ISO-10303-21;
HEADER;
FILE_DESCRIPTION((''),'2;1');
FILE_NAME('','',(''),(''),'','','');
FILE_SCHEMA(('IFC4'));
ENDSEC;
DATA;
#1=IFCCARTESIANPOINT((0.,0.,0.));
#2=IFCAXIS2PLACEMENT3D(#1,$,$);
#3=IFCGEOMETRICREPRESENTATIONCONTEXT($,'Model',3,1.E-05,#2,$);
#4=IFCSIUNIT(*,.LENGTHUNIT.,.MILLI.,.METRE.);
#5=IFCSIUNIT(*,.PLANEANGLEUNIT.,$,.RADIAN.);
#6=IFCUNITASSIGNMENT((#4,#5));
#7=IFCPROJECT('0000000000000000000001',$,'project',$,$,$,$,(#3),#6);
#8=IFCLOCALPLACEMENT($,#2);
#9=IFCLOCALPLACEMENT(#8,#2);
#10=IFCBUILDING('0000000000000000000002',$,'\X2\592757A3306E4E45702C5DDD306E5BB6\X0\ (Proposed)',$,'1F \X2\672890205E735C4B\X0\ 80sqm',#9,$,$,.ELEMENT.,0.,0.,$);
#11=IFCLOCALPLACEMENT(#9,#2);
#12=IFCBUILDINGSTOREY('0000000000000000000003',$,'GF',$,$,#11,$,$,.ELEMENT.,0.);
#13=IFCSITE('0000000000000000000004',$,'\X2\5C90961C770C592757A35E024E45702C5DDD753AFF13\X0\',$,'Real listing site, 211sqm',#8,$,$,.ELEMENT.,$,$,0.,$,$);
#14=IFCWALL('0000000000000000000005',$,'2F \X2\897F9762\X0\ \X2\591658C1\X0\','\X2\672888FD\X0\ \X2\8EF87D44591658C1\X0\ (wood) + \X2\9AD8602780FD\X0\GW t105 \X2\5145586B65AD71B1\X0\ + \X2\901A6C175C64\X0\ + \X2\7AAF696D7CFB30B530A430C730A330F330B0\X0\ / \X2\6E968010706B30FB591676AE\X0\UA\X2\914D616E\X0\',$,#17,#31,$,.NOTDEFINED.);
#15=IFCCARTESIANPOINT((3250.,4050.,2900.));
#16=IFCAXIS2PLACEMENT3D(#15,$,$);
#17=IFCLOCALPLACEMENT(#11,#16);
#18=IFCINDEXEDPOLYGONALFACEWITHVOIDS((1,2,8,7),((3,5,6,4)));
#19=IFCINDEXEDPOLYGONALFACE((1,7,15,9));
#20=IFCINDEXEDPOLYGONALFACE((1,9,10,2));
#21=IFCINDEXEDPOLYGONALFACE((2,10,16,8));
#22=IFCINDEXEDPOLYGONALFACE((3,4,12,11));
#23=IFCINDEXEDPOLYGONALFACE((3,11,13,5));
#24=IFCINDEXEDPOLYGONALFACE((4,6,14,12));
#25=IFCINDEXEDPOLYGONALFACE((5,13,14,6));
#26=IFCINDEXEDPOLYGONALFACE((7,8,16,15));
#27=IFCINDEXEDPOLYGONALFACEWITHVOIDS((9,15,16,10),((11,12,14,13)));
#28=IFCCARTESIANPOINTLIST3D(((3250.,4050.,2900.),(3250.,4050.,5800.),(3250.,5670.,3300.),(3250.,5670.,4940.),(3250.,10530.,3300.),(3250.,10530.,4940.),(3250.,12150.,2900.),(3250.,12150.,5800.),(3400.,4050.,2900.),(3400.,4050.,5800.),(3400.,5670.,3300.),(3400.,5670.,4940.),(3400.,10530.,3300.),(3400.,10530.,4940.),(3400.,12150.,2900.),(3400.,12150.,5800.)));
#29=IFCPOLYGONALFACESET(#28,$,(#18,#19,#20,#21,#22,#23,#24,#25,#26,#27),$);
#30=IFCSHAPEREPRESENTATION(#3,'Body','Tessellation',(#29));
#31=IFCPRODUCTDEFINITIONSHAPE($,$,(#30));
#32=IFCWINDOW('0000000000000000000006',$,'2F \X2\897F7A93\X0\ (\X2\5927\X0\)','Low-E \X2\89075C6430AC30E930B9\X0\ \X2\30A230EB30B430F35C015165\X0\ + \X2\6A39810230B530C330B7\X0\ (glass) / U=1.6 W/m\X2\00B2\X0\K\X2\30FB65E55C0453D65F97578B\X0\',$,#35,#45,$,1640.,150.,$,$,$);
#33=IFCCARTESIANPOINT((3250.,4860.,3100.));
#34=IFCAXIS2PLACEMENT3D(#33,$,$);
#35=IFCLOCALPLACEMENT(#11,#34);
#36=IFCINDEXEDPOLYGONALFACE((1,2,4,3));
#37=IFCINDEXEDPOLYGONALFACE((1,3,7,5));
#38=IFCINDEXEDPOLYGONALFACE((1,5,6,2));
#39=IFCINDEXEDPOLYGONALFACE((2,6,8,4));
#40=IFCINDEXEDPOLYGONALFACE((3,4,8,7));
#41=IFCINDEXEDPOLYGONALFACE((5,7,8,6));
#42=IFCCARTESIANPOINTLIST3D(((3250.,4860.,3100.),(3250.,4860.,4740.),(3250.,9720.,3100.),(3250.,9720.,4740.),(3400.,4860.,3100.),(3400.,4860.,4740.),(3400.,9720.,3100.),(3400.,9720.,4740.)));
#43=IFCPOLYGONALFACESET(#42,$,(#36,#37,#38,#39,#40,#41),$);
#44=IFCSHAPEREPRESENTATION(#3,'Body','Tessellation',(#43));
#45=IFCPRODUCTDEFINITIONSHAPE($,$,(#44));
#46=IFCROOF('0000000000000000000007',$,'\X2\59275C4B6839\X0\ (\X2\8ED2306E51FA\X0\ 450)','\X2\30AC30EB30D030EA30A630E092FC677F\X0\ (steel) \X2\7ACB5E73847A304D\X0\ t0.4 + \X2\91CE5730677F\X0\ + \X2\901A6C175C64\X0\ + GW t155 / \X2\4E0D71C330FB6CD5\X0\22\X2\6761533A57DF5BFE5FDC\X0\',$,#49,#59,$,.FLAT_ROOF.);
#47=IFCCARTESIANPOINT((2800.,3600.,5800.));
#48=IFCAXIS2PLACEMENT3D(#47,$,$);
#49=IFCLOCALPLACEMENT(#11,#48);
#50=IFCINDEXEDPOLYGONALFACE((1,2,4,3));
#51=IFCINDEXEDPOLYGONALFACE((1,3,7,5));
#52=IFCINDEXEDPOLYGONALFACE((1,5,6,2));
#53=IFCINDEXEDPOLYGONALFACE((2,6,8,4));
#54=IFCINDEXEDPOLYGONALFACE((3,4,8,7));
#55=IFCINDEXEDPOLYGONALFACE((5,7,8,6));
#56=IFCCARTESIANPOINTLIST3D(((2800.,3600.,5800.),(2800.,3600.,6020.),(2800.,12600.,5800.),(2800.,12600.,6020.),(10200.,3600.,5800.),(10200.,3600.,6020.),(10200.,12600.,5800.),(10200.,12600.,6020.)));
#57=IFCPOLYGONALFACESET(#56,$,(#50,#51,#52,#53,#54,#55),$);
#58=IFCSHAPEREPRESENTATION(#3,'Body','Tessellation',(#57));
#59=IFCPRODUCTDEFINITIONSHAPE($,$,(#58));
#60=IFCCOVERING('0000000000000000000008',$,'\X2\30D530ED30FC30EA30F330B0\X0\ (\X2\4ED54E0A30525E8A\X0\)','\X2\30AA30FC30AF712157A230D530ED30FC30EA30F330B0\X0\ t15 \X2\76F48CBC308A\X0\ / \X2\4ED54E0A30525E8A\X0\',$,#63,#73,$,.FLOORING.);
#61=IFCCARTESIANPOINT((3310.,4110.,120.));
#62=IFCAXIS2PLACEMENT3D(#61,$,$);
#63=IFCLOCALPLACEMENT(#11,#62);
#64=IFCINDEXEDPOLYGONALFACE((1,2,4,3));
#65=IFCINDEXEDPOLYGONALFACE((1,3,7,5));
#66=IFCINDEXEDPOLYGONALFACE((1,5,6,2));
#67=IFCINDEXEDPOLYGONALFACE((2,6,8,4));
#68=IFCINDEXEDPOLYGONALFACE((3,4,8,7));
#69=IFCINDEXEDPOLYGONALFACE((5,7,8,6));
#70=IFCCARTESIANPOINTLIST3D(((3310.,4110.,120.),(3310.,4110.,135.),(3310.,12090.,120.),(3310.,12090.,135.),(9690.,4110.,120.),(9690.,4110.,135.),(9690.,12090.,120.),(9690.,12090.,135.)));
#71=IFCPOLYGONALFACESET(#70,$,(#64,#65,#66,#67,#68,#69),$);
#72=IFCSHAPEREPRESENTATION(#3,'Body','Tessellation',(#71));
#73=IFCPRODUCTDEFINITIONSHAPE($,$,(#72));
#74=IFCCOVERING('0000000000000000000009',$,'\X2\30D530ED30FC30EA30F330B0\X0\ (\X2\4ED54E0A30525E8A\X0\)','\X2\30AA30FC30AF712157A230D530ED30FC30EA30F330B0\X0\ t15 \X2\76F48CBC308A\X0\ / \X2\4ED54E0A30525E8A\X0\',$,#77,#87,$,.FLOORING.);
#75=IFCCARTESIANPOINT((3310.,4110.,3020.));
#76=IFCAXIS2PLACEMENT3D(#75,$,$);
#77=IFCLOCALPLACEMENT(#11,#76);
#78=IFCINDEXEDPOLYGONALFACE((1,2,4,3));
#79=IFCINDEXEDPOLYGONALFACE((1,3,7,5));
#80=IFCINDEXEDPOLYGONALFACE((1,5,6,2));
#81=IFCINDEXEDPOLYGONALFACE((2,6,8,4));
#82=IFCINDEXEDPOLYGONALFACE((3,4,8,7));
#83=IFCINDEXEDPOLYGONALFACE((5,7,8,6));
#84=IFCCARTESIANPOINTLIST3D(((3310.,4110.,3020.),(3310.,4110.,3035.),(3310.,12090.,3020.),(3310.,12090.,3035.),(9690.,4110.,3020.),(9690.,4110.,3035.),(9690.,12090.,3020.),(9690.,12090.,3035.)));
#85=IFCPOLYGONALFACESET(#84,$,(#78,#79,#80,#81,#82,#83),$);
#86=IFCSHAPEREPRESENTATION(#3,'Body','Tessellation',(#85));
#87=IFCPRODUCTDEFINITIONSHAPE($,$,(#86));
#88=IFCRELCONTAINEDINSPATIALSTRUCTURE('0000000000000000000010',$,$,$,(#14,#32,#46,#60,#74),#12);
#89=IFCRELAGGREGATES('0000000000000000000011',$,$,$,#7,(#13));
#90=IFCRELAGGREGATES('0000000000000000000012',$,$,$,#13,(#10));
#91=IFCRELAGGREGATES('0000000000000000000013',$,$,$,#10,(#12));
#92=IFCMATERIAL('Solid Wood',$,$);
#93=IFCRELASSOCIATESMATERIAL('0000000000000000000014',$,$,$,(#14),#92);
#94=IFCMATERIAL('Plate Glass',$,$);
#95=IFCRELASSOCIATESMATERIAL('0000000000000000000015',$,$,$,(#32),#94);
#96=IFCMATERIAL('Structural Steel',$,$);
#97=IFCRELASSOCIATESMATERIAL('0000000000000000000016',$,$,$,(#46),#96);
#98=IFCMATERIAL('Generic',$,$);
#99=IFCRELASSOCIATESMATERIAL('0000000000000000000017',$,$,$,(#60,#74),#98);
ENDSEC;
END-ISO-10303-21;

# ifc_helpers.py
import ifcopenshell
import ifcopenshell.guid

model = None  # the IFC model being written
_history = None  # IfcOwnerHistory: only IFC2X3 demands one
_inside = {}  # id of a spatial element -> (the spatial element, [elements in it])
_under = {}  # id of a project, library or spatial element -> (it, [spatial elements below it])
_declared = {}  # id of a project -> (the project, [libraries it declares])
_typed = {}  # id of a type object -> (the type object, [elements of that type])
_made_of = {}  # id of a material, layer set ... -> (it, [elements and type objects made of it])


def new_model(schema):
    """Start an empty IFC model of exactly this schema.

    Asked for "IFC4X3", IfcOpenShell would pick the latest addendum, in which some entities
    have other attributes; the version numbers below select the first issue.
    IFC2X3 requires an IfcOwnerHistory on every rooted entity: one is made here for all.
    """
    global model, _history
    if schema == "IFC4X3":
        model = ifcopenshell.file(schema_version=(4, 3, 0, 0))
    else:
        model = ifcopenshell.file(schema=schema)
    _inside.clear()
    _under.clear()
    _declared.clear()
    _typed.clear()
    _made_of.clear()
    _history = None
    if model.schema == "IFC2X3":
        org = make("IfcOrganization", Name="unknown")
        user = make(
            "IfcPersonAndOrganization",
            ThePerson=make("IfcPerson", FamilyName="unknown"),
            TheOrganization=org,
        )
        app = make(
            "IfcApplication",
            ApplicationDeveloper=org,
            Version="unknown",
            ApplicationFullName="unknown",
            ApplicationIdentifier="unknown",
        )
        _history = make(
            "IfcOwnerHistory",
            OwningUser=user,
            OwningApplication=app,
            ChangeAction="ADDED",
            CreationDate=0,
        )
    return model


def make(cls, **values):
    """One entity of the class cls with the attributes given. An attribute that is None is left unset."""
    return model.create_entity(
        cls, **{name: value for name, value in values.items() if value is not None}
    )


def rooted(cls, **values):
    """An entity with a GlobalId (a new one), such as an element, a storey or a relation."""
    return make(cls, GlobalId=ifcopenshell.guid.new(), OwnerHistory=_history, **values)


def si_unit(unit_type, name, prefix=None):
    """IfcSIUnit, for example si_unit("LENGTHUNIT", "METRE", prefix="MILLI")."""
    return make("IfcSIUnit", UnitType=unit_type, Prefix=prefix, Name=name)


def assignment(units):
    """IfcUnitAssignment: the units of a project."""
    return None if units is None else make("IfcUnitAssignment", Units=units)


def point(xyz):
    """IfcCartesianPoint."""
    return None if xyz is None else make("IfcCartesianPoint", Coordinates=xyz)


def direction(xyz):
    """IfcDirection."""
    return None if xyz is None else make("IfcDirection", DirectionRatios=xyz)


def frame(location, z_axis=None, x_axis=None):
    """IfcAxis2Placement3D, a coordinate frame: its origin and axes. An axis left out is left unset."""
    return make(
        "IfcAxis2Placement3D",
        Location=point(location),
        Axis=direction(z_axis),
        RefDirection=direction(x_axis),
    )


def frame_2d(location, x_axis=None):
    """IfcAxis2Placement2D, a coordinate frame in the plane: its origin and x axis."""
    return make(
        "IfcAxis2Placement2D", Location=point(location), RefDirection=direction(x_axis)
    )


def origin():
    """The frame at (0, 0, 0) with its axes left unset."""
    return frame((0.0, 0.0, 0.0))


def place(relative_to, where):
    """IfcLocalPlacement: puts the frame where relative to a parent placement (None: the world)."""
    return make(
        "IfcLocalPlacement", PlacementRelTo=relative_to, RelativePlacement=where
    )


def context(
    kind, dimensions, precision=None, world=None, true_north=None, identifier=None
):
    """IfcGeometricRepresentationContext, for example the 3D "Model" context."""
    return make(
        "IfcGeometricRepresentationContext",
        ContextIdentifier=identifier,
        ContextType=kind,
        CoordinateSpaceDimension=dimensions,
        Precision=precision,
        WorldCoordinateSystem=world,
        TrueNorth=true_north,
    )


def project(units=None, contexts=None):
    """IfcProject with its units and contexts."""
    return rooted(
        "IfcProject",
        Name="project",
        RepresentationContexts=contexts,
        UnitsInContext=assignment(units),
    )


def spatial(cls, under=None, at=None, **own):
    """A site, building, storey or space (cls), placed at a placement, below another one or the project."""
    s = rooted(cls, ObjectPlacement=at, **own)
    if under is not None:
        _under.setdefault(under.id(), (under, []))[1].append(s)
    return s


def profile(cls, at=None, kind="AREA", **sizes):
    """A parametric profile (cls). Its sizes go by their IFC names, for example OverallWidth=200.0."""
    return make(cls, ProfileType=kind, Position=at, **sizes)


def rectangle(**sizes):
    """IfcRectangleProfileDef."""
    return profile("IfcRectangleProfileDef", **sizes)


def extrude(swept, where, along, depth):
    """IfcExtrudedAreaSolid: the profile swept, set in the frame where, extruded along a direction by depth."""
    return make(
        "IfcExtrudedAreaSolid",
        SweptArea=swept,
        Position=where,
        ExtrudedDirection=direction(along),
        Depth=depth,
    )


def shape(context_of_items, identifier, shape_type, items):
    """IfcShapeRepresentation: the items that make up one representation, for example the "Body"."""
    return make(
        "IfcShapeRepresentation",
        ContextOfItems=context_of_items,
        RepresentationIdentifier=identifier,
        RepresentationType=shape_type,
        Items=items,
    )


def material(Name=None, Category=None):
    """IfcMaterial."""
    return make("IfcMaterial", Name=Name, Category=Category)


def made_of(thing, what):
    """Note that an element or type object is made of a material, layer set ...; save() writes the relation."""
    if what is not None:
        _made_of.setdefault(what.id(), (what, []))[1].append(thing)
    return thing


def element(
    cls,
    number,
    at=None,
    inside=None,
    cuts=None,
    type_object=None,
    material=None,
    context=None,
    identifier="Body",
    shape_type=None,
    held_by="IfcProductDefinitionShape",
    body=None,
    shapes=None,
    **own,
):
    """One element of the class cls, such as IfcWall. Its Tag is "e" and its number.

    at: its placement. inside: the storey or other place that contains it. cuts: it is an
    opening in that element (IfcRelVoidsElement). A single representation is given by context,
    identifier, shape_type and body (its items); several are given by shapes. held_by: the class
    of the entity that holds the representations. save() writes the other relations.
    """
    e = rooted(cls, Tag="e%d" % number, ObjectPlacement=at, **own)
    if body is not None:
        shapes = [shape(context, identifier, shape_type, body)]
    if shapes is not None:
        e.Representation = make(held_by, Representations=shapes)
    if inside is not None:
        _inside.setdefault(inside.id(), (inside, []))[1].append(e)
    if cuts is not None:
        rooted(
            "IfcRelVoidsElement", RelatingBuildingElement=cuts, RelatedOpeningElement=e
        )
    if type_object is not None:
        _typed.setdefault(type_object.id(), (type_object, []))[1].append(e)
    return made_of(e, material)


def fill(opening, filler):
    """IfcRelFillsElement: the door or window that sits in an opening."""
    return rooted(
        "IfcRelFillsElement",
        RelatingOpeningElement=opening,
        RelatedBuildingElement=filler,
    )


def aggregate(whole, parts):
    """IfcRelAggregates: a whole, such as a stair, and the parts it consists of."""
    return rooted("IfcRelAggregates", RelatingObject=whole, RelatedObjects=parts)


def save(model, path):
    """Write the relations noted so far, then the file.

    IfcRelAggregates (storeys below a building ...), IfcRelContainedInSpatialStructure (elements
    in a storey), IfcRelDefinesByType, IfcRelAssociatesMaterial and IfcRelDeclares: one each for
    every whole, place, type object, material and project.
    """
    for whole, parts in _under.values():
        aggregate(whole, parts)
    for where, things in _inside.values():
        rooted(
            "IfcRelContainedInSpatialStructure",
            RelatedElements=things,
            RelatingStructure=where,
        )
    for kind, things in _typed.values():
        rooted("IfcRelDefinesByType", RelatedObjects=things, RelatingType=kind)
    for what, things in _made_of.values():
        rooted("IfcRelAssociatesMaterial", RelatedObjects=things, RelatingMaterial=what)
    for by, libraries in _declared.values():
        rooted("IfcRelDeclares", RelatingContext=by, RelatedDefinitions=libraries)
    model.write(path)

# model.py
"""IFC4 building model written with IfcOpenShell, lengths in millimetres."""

from ifc_helpers import new_model, si_unit, frame, frame_2d, origin, place, context, project, spatial, rectangle, extrude, material, element, fill, save


model = new_model("IFC4")

# Units and contexts
model_context = context("Model", 3, precision=1e-05, world=origin())
ifc_project = project(units=[si_unit("LENGTHUNIT", "METRE", prefix="MILLI"), si_unit("PLANEANGLEUNIT", "RADIAN")], contexts=[model_context])

# Site, building, storey
site_placement = place(None, origin())
site = spatial("IfcSite", under=ifc_project, at=site_placement, Name="岐阜県大垣市久瀬川町３", ObjectType="Real listing site, 211sqm", CompositionType="ELEMENT", RefElevation=0.0)
building_placement = place(site_placement, origin())
building = spatial("IfcBuilding", under=site, at=building_placement, Name="大垣の久瀬川の家 (Proposed)", ObjectType="1F 木造平屋 80sqm", CompositionType="ELEMENT", ElevationOfRefHeight=0.0, ElevationOfTerrain=0.0)
storey_placement = place(building_placement, origin())
storey = spatial("IfcBuildingStorey", under=building, at=storey_placement, Name="GF", CompositionType="ELEMENT", Elevation=0.0)

# Shared definitions
ifc_material_1 = material(Name="Solid Wood")
ifc_material_2 = material(Name="Generic")

# Shared definitions
ifc_material_3 = material(Name="Plate Glass")

# Wall, opening, window
wall_1_placement = place(storey_placement, frame((3250.0, 4050.0, 2900.0)))
wall_1 = element("IfcWall", 1, at=wall_1_placement, inside=storey, material=ifc_material_1, Name="2F 西面 外壁", Description="木製 軸組外壁 (wood) + 高性能GW t105 充填断熱 + 通気層 + 窯業系サイディング / 準耐火・外皮UA配慮", PredefinedType="NOTDEFINED", context=model_context, shape_type="SweptSolid", body=[
    extrude(rectangle(XDim=150.0, YDim=8100.0, at=frame_2d((75.0, 4050.0))), frame((3250.0, 4050.0, 2900.0)), (0.0, 0.0, 1.0), 2900.0),
])
opening_1_placement = place(storey_placement, frame((3250.0, 4860.0, 3100.0)))
opening_1 = element("IfcOpeningElement", 2, at=opening_1_placement, cuts=wall_1, PredefinedType="NOTDEFINED", context=model_context, shape_type="SweptSolid", body=[
    extrude(rectangle(XDim=150.0, YDim=4860.0, at=frame_2d((75.0, 2430.0))), frame((3250.0, 4860.0, 3100.0)), (0.0, 0.0, 1.0), 1640.0),
])
window_1_placement = place(storey_placement, frame((3250.0, 4860.0, 3100.0)))
window_1 = element("IfcWindow", 3, at=window_1_placement, inside=storey, material=ifc_material_3, Name="2F 西窓 (大)", Description="Low-E 複層ガラス アルゴン封入 + 樹脂サッシ (glass) / U=1.6 W/m²K・日射取得型", OverallHeight=1640.0, OverallWidth=150.0, context=model_context, shape_type="SweptSolid", body=[
    extrude(rectangle(XDim=150.0, YDim=4860.0, at=frame_2d((75.0, 2430.0))), frame((3250.0, 4860.0, 3100.0)), (0.0, 0.0, 1.0), 1640.0),
])
fill(opening_1, window_1)

# Roof
ifc_material_4 = material(Name="Structural Steel")
roof_placement = place(storey_placement, frame((2800.0, 3600.0, 5800.0)))
element("IfcRoof", 4, at=roof_placement, inside=storey, material=ifc_material_4, Name="大屋根 (軒の出 450)", Description="ガルバリウム鋼板 (steel) 立平葺き t0.4 + 野地板 + 通気層 + GW t155 / 不燃・法22条区域対応", PredefinedType="FLAT_ROOF", context=model_context, shape_type="SweptSolid", body=[
    extrude(rectangle(XDim=7400.0, YDim=9000.0, at=frame_2d((3700.0, 4500.0))), frame((2800.0, 3600.0, 5800.0)), (0.0, 0.0, 1.0), 220.0),
])

# Coverings
covering_1_placement = place(storey_placement, frame((3310.0, 4110.0, 120.0)))
element("IfcCovering", 5, at=covering_1_placement, inside=storey, material=ifc_material_2, Name="フローリング (仕上げ床)", Description="オーク無垢フローリング t15 直貼り / 仕上げ床", PredefinedType="FLOORING", context=model_context, shape_type="SweptSolid", body=[
    extrude(rectangle(XDim=6380.0, YDim=7980.0, at=frame_2d((3190.0, 3990.0))), frame((3310.0, 4110.0, 120.0)), (0.0, 0.0, 1.0), 15.0),
])
covering_2_placement = place(storey_placement, frame((3310.0, 4110.0, 3020.0)))
element("IfcCovering", 6, at=covering_2_placement, inside=storey, material=ifc_material_2, Name="フローリング (仕上げ床)", Description="オーク無垢フローリング t15 直貼り / 仕上げ床", PredefinedType="FLOORING", context=model_context, shape_type="SweptSolid", body=[
    extrude(rectangle(XDim=6380.0, YDim=7980.0, at=frame_2d((3190.0, 3990.0))), frame((3310.0, 4110.0, 3020.0)), (0.0, 0.0, 1.0), 15.0),
])

save(model, "model.ifc")
